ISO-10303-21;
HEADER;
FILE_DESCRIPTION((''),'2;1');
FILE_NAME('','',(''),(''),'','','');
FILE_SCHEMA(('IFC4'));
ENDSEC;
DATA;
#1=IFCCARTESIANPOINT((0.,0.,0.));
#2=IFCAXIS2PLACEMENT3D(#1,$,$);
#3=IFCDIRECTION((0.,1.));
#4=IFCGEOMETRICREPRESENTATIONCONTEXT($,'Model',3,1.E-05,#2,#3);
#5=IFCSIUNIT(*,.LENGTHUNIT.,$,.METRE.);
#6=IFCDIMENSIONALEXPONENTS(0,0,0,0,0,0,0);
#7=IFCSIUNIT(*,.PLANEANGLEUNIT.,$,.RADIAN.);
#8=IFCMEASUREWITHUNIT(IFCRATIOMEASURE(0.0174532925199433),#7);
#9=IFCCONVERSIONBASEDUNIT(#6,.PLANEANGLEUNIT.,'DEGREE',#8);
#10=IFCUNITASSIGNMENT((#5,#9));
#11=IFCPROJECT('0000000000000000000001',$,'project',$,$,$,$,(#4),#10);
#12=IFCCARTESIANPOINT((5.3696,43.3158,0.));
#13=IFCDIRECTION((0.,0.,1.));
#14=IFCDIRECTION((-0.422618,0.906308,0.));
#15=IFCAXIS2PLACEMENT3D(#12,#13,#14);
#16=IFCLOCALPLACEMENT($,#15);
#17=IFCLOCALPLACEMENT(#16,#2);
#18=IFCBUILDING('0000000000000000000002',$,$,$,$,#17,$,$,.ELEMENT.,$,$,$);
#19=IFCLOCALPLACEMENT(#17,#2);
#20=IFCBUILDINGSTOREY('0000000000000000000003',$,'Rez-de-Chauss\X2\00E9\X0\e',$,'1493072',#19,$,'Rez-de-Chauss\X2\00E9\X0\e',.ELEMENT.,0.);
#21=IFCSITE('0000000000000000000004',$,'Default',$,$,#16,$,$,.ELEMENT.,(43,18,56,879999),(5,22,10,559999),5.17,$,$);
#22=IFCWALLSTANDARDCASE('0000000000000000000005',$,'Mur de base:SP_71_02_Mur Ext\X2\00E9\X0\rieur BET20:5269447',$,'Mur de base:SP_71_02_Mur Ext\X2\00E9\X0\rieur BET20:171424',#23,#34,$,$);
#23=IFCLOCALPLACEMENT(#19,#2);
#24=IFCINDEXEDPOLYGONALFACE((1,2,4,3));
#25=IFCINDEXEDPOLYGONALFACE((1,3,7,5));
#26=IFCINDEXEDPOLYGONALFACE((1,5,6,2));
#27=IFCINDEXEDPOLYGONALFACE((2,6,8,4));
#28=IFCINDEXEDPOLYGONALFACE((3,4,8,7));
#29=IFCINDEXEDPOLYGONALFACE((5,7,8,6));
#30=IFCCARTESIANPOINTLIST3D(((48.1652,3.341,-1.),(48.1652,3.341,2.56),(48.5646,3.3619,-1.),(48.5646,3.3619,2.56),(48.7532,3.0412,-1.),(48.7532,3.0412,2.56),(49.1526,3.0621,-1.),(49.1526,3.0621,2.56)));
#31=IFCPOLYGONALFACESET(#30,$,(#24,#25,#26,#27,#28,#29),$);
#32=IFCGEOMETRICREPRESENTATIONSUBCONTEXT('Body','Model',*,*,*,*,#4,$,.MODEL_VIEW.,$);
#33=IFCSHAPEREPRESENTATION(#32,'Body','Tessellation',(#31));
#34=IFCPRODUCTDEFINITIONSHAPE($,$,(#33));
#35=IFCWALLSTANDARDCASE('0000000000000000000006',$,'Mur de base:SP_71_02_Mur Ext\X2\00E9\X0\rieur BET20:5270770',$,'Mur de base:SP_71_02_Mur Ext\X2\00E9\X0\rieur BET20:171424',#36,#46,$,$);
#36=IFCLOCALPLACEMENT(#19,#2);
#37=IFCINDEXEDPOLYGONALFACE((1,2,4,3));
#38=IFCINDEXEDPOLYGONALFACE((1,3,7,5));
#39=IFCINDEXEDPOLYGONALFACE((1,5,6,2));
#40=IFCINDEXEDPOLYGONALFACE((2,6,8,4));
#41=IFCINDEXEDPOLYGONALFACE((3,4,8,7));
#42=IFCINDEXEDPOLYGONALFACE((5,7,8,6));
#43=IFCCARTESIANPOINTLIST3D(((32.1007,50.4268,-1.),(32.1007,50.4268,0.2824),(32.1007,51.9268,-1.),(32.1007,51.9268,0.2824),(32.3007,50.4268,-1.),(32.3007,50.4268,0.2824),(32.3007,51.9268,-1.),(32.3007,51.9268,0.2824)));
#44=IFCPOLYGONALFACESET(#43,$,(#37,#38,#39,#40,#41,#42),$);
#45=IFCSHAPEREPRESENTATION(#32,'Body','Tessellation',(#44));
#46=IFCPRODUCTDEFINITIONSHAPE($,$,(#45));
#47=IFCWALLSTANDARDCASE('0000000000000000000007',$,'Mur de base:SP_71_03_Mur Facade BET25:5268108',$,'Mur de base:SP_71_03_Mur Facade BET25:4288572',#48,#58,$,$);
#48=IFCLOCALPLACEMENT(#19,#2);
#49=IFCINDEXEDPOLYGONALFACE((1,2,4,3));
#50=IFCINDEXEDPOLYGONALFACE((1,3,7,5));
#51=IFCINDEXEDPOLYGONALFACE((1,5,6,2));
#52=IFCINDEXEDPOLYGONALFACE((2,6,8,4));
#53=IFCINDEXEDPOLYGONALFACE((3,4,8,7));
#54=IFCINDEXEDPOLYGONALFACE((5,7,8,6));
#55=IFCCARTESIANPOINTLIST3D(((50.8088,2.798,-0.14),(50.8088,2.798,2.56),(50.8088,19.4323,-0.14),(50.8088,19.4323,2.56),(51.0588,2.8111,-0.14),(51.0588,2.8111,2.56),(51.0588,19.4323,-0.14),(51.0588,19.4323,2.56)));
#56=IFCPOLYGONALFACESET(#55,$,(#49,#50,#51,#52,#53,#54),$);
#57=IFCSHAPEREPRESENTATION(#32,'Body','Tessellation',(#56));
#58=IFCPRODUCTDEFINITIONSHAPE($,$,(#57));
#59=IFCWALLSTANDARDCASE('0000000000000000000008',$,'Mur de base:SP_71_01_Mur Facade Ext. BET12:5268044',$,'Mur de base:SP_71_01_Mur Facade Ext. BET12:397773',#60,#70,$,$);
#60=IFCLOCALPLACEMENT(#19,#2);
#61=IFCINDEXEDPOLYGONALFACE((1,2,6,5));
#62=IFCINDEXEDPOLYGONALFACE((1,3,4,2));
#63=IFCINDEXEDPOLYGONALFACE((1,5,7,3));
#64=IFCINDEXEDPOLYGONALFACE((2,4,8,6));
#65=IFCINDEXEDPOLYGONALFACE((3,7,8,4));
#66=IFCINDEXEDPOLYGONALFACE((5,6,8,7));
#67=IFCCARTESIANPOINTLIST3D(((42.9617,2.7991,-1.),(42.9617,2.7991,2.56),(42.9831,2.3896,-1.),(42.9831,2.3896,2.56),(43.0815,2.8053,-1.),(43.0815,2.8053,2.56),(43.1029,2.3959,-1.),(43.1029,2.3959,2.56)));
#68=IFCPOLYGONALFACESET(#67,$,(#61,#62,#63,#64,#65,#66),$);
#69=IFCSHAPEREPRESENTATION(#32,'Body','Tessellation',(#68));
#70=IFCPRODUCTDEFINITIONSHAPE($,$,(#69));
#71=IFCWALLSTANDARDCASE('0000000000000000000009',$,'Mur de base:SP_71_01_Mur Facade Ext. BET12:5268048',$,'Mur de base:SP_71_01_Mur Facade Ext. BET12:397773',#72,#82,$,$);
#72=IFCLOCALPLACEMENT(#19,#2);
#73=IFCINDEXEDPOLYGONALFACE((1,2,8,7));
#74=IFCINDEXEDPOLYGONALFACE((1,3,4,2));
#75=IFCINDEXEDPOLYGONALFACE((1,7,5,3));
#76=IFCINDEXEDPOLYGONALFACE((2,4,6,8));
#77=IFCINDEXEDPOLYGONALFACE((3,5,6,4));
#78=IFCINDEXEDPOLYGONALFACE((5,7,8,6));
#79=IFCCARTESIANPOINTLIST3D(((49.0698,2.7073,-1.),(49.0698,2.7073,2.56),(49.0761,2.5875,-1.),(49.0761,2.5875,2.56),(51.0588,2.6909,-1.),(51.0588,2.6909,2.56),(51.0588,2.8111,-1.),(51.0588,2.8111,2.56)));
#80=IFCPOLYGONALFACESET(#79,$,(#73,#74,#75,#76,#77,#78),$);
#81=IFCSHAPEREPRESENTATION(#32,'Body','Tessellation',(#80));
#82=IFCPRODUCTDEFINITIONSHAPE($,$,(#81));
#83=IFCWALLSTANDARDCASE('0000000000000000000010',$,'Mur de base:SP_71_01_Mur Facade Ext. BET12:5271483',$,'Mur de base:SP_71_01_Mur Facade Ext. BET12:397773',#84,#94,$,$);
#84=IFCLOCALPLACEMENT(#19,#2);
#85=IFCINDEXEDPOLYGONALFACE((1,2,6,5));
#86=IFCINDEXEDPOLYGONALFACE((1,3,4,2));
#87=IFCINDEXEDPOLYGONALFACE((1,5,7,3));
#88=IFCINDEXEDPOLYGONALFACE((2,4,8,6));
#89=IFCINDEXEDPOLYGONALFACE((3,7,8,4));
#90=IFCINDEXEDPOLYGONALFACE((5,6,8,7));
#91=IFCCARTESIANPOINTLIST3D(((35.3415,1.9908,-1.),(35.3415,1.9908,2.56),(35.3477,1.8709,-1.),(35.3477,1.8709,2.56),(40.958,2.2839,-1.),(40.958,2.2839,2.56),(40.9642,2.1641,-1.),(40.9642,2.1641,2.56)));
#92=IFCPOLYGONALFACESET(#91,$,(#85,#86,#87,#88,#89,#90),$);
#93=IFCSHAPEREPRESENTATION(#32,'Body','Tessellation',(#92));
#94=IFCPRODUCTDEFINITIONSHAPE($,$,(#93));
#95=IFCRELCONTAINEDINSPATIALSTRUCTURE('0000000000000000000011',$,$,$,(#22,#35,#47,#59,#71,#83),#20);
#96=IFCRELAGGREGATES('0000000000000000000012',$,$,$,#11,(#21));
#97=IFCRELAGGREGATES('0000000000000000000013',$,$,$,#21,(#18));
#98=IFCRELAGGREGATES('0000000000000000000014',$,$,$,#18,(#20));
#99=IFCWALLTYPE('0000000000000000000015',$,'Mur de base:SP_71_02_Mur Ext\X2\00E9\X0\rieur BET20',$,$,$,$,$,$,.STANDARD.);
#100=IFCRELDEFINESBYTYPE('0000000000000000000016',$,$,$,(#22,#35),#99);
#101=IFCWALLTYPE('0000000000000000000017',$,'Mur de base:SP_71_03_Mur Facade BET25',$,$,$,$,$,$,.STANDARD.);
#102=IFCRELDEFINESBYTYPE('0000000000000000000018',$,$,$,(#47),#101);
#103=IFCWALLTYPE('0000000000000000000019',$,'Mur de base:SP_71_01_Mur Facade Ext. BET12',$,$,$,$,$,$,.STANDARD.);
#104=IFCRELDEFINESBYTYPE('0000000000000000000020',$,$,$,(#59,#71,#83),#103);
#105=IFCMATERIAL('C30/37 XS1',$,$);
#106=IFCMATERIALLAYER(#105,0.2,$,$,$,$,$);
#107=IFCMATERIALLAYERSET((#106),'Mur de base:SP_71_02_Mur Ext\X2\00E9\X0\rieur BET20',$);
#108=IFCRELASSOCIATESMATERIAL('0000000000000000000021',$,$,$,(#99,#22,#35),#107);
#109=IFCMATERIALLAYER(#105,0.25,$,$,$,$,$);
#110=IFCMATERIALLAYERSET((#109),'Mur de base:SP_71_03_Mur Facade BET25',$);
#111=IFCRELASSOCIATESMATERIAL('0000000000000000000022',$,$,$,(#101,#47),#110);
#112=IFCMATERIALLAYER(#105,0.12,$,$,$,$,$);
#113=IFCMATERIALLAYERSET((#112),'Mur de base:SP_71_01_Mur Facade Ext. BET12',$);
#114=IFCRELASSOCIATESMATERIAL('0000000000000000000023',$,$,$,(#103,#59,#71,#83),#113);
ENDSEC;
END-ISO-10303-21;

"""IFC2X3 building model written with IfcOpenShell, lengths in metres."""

from ifc_helpers import new_model, entity, si_unit, converted_unit, direction, frame, frame_2d, origin, place, context, subcontext, project, spatial, polyline, rectangle, outline, extrude, clip, halfspace, bounded_halfspace, material, layer, layer_set, layer_usage, type_object, element, save


model = new_model("IFC2X3")

# Units and contexts
model_context = context("Model", 3, precision=1e-05, world=origin(), true_north=direction((0.0, 1.0)))
body_context = subcontext(model_context, "Body", "Model", "MODEL_VIEW")
ifc_project = project(units=[si_unit("LENGTHUNIT", "METRE"), converted_unit("PLANEANGLEUNIT", "DEGREE", entity("IfcRatioMeasure", 0.0174532925199433), si_unit("PLANEANGLEUNIT", "RADIAN"), dimensions=[0, 0, 0, 0, 0, 0, 0])], contexts=[model_context])

# Site, building, storey
site_placement = place(None, frame((5.3696, 43.3158, 0.0), z_axis=(0.0, 0.0, 1.0), x_axis=(-0.422618, 0.906308, 0.0)))
site = spatial("IfcSite", under=ifc_project, at=site_placement, Name="Default", CompositionType="ELEMENT", RefLatitude=(43, 18, 56, 879999), RefLongitude=(5, 22, 10, 559999), RefElevation=5.17)
building_placement = place(site_placement, origin())
building = spatial("IfcBuilding", under=site, at=building_placement, CompositionType="ELEMENT")
storey_placement = place(building_placement, origin())
storey = spatial("IfcBuildingStorey", under=building, at=storey_placement, Name="Rez-de-Chaussée", ObjectType="1493072", LongName="Rez-de-Chaussée", CompositionType="ELEMENT", Elevation=0.0)

# Shared definitions
ifc_material_1 = material(Name="C30/37 XS1")

# Shared definitions
ifc_layer_1 = layer(ifc_material_1, 0.2)
ifc_layer_set_1 = layer_set([ifc_layer_1], Name="Mur de base:SP_71_02_Mur Extérieur BET20")
wall_type_1 = type_object("IfcWallType", Name="Mur de base:SP_71_02_Mur Extérieur BET20", PredefinedType="STANDARD", material=ifc_layer_set_1)

# Walls
ifc_layer_usage_1 = layer_usage(ifc_layer_set_1, "AXIS2", "NEGATIVE", 0.1)
wall_1_placement = place(storey_placement, frame((48.2106, 3.4301, -1.0), z_axis=(0.0, 0.0, 1.0), x_axis=(0.890908, -0.454183, 0.0)))
element("IfcWallStandardCase", 1, at=wall_1_placement, inside=storey, type_object=wall_type_1, material=ifc_layer_usage_1, Name="Mur de base:SP_71_02_Mur Extérieur BET20:5269447", ObjectType="Mur de base:SP_71_02_Mur Extérieur BET20:171424", context=body_context, shape_type="SweptSolid", body=[
    extrude(outline(polyline([(0.0858, -0.165), (0.4858, -0.165), (-0.0858, 0.165), (-0.4858, 0.165), (0.0858, -0.165)])), frame((0.5032, 0.0, 0.0), z_axis=(0.0, 0.0, 1.0), x_axis=(0.866025, 0.5, 0.0)), (0.0, 0.0, 1.0), 3.56),
])
ifc_layer_usage_2 = layer_usage(ifc_layer_set_1, "AXIS2", "POSITIVE", -0.1)
wall_2_placement = place(storey_placement, frame((32.2007, 51.9268, -1.0), z_axis=(0.0, 0.0, 1.0), x_axis=(0.0, -1.0, 0.0)))
element("IfcWallStandardCase", 2, at=wall_2_placement, inside=storey, type_object=wall_type_1, material=ifc_layer_usage_2, Name="Mur de base:SP_71_02_Mur Extérieur BET20:5270770", ObjectType="Mur de base:SP_71_02_Mur Extérieur BET20:171424", context=body_context, shape_type="SweptSolid", body=[
    extrude(rectangle(XDim=1.5, YDim=0.2, at=frame_2d((0.75, 0.0), x_axis=(-1.0, 0.0))), origin(), (0.0, 0.0, 1.0), 1.2824),
])

# Wall
ifc_layer_2 = layer(ifc_material_1, 0.25)
ifc_layer_set_2 = layer_set([ifc_layer_2], Name="Mur de base:SP_71_03_Mur Facade BET25")
ifc_layer_usage_3 = layer_usage(ifc_layer_set_2, "AXIS2", "NEGATIVE", 0.125)
wall_type_2 = type_object("IfcWallType", Name="Mur de base:SP_71_03_Mur Facade BET25", PredefinedType="STANDARD", material=ifc_layer_set_2)
wall_3_placement = place(storey_placement, frame((50.9338, 19.4323, -0.14), z_axis=(0.0, 0.0, 1.0), x_axis=(0.0, -1.0, 0.0)))
element("IfcWallStandardCase", 3, at=wall_3_placement, inside=storey, type_object=wall_type_2, material=ifc_layer_usage_3, Name="Mur de base:SP_71_03_Mur Facade BET25:5268108", ObjectType="Mur de base:SP_71_03_Mur Facade BET25:4288572", context=body_context, shape_type="Clipping", body=[
    clip(extrude(outline(polyline([(16.6343, -0.125), (16.6212, 0.125), (0.0, 0.125), (0.0, -0.125), (16.6343, -0.125)])), origin(), (0.0, 0.0, 1.0), 2.7), halfspace(frame((0.0, 0.0, -0.14)), True)),
])
ifc_layer_3 = layer(ifc_material_1, 0.12)
ifc_layer_set_3 = layer_set([ifc_layer_3], Name="Mur de base:SP_71_01_Mur Facade Ext. BET12")
wall_type_3 = type_object("IfcWallType", Name="Mur de base:SP_71_01_Mur Facade Ext. BET12", PredefinedType="STANDARD", material=ifc_layer_set_3)

# Wall, opening
ifc_layer_usage_4 = layer_usage(ifc_layer_set_3, "AXIS2", "NEGATIVE", 0.06)
wall_4_placement = place(storey_placement, frame((43.0216, 2.8022, -1.0), z_axis=(0.0, 0.0, 1.0), x_axis=(0.05212, -0.998641, 0.0)))
wall_4 = element("IfcWallStandardCase", 4, at=wall_4_placement, inside=storey, type_object=wall_type_3, material=ifc_layer_usage_4, Name="Mur de base:SP_71_01_Mur Facade Ext. BET12:5268044", ObjectType="Mur de base:SP_71_01_Mur Facade Ext. BET12:397773", context=body_context, shape_type="Clipping", body=[
    clip(extrude(rectangle(XDim=0.41, YDim=0.12, at=frame_2d((0.205, 0.0), x_axis=(-1.0, 0.0))), origin(), (0.0, 0.0, 1.0), 3.56), halfspace(frame((0.0, 0.0, -1.0)), True)),
])
opening_1_placement = place(wall_4_placement, origin())
element("IfcOpeningElement", 5, at=opening_1_placement, cuts=wall_4, ObjectType="Opening", context=body_context, shape_type="SweptSolid", body=[
    extrude(rectangle(XDim=2.24, YDim=0.12, at=frame_2d((0.0, 0.0), x_axis=(0.0, 1.0))), frame((-0.06, 0.06, 3.24), z_axis=(0.0, 1.0, 0.0), x_axis=(1.0, 0.0, 0.0)), (0.0, 0.0, 1.0), 5.02),
])

# Walls
ifc_layer_usage_5 = layer_usage(ifc_layer_set_3, "AXIS2", "NEGATIVE", 0.06)
wall_5_placement = place(storey_placement, frame((51.0619, 2.7512, -1.0), z_axis=(0.0, 0.0, 1.0), x_axis=(-0.998641, -0.05212, 0.0)))
element("IfcWallStandardCase", 6, at=wall_5_placement, inside=storey, type_object=wall_type_3, material=ifc_layer_usage_5, Name="Mur de base:SP_71_01_Mur Facade Ext. BET12:5268048", ObjectType="Mur de base:SP_71_01_Mur Facade Ext. BET12:397773", context=body_context, shape_type="Clipping", body=[
    clip(extrude(outline(polyline([(1.9917, -0.06), (1.9917, 0.06), (0.0063, 0.06), (0.0, -0.06), (1.9843, -0.06), (1.9917, -0.06)])), origin(), (0.0, 0.0, 1.0), 3.56), halfspace(frame((0.0, 0.0, -1.0)), True)),
])
ifc_layer_usage_6 = layer_usage(ifc_layer_set_3, "AXIS2", "NEGATIVE", 0.06)
wall_6_placement = place(storey_placement, frame((40.9611, 2.224, -1.0), z_axis=(0.0, 0.0, 1.0), x_axis=(-0.998641, -0.05212, 0.0)))
element("IfcWallStandardCase", 7, at=wall_6_placement, inside=storey, type_object=wall_type_3, material=ifc_layer_usage_6, Name="Mur de base:SP_71_01_Mur Facade Ext. BET12:5271483", ObjectType="Mur de base:SP_71_01_Mur Facade Ext. BET12:397773", context=body_context, shape_type="Clipping", body=[
    clip(clip(extrude(rectangle(XDim=0.12, YDim=5.6242, at=frame_2d((2.8121, 0.0), x_axis=(0.0, 1.0))), origin(), (0.0, 0.0, 1.0), 3.56), bounded_halfspace(frame((5.6242, -0.06, 0.86), z_axis=(-1.0, 0.0, 0.0), x_axis=(0.0, -1.0, 0.0)), True, frame((5.6242, -0.06, 0.86), z_axis=(-1.0, 0.0, 0.0), x_axis=(0.0, -1.0, 0.0)), polyline([(0.0, 0.0), (-0.12, 0.0), (-0.12, -0.86), (0.0, -0.86), (0.0, 0.0)]))), halfspace(frame((0.0, 0.0, -1.0)), True)),
])

save(model, "model.ifc")
